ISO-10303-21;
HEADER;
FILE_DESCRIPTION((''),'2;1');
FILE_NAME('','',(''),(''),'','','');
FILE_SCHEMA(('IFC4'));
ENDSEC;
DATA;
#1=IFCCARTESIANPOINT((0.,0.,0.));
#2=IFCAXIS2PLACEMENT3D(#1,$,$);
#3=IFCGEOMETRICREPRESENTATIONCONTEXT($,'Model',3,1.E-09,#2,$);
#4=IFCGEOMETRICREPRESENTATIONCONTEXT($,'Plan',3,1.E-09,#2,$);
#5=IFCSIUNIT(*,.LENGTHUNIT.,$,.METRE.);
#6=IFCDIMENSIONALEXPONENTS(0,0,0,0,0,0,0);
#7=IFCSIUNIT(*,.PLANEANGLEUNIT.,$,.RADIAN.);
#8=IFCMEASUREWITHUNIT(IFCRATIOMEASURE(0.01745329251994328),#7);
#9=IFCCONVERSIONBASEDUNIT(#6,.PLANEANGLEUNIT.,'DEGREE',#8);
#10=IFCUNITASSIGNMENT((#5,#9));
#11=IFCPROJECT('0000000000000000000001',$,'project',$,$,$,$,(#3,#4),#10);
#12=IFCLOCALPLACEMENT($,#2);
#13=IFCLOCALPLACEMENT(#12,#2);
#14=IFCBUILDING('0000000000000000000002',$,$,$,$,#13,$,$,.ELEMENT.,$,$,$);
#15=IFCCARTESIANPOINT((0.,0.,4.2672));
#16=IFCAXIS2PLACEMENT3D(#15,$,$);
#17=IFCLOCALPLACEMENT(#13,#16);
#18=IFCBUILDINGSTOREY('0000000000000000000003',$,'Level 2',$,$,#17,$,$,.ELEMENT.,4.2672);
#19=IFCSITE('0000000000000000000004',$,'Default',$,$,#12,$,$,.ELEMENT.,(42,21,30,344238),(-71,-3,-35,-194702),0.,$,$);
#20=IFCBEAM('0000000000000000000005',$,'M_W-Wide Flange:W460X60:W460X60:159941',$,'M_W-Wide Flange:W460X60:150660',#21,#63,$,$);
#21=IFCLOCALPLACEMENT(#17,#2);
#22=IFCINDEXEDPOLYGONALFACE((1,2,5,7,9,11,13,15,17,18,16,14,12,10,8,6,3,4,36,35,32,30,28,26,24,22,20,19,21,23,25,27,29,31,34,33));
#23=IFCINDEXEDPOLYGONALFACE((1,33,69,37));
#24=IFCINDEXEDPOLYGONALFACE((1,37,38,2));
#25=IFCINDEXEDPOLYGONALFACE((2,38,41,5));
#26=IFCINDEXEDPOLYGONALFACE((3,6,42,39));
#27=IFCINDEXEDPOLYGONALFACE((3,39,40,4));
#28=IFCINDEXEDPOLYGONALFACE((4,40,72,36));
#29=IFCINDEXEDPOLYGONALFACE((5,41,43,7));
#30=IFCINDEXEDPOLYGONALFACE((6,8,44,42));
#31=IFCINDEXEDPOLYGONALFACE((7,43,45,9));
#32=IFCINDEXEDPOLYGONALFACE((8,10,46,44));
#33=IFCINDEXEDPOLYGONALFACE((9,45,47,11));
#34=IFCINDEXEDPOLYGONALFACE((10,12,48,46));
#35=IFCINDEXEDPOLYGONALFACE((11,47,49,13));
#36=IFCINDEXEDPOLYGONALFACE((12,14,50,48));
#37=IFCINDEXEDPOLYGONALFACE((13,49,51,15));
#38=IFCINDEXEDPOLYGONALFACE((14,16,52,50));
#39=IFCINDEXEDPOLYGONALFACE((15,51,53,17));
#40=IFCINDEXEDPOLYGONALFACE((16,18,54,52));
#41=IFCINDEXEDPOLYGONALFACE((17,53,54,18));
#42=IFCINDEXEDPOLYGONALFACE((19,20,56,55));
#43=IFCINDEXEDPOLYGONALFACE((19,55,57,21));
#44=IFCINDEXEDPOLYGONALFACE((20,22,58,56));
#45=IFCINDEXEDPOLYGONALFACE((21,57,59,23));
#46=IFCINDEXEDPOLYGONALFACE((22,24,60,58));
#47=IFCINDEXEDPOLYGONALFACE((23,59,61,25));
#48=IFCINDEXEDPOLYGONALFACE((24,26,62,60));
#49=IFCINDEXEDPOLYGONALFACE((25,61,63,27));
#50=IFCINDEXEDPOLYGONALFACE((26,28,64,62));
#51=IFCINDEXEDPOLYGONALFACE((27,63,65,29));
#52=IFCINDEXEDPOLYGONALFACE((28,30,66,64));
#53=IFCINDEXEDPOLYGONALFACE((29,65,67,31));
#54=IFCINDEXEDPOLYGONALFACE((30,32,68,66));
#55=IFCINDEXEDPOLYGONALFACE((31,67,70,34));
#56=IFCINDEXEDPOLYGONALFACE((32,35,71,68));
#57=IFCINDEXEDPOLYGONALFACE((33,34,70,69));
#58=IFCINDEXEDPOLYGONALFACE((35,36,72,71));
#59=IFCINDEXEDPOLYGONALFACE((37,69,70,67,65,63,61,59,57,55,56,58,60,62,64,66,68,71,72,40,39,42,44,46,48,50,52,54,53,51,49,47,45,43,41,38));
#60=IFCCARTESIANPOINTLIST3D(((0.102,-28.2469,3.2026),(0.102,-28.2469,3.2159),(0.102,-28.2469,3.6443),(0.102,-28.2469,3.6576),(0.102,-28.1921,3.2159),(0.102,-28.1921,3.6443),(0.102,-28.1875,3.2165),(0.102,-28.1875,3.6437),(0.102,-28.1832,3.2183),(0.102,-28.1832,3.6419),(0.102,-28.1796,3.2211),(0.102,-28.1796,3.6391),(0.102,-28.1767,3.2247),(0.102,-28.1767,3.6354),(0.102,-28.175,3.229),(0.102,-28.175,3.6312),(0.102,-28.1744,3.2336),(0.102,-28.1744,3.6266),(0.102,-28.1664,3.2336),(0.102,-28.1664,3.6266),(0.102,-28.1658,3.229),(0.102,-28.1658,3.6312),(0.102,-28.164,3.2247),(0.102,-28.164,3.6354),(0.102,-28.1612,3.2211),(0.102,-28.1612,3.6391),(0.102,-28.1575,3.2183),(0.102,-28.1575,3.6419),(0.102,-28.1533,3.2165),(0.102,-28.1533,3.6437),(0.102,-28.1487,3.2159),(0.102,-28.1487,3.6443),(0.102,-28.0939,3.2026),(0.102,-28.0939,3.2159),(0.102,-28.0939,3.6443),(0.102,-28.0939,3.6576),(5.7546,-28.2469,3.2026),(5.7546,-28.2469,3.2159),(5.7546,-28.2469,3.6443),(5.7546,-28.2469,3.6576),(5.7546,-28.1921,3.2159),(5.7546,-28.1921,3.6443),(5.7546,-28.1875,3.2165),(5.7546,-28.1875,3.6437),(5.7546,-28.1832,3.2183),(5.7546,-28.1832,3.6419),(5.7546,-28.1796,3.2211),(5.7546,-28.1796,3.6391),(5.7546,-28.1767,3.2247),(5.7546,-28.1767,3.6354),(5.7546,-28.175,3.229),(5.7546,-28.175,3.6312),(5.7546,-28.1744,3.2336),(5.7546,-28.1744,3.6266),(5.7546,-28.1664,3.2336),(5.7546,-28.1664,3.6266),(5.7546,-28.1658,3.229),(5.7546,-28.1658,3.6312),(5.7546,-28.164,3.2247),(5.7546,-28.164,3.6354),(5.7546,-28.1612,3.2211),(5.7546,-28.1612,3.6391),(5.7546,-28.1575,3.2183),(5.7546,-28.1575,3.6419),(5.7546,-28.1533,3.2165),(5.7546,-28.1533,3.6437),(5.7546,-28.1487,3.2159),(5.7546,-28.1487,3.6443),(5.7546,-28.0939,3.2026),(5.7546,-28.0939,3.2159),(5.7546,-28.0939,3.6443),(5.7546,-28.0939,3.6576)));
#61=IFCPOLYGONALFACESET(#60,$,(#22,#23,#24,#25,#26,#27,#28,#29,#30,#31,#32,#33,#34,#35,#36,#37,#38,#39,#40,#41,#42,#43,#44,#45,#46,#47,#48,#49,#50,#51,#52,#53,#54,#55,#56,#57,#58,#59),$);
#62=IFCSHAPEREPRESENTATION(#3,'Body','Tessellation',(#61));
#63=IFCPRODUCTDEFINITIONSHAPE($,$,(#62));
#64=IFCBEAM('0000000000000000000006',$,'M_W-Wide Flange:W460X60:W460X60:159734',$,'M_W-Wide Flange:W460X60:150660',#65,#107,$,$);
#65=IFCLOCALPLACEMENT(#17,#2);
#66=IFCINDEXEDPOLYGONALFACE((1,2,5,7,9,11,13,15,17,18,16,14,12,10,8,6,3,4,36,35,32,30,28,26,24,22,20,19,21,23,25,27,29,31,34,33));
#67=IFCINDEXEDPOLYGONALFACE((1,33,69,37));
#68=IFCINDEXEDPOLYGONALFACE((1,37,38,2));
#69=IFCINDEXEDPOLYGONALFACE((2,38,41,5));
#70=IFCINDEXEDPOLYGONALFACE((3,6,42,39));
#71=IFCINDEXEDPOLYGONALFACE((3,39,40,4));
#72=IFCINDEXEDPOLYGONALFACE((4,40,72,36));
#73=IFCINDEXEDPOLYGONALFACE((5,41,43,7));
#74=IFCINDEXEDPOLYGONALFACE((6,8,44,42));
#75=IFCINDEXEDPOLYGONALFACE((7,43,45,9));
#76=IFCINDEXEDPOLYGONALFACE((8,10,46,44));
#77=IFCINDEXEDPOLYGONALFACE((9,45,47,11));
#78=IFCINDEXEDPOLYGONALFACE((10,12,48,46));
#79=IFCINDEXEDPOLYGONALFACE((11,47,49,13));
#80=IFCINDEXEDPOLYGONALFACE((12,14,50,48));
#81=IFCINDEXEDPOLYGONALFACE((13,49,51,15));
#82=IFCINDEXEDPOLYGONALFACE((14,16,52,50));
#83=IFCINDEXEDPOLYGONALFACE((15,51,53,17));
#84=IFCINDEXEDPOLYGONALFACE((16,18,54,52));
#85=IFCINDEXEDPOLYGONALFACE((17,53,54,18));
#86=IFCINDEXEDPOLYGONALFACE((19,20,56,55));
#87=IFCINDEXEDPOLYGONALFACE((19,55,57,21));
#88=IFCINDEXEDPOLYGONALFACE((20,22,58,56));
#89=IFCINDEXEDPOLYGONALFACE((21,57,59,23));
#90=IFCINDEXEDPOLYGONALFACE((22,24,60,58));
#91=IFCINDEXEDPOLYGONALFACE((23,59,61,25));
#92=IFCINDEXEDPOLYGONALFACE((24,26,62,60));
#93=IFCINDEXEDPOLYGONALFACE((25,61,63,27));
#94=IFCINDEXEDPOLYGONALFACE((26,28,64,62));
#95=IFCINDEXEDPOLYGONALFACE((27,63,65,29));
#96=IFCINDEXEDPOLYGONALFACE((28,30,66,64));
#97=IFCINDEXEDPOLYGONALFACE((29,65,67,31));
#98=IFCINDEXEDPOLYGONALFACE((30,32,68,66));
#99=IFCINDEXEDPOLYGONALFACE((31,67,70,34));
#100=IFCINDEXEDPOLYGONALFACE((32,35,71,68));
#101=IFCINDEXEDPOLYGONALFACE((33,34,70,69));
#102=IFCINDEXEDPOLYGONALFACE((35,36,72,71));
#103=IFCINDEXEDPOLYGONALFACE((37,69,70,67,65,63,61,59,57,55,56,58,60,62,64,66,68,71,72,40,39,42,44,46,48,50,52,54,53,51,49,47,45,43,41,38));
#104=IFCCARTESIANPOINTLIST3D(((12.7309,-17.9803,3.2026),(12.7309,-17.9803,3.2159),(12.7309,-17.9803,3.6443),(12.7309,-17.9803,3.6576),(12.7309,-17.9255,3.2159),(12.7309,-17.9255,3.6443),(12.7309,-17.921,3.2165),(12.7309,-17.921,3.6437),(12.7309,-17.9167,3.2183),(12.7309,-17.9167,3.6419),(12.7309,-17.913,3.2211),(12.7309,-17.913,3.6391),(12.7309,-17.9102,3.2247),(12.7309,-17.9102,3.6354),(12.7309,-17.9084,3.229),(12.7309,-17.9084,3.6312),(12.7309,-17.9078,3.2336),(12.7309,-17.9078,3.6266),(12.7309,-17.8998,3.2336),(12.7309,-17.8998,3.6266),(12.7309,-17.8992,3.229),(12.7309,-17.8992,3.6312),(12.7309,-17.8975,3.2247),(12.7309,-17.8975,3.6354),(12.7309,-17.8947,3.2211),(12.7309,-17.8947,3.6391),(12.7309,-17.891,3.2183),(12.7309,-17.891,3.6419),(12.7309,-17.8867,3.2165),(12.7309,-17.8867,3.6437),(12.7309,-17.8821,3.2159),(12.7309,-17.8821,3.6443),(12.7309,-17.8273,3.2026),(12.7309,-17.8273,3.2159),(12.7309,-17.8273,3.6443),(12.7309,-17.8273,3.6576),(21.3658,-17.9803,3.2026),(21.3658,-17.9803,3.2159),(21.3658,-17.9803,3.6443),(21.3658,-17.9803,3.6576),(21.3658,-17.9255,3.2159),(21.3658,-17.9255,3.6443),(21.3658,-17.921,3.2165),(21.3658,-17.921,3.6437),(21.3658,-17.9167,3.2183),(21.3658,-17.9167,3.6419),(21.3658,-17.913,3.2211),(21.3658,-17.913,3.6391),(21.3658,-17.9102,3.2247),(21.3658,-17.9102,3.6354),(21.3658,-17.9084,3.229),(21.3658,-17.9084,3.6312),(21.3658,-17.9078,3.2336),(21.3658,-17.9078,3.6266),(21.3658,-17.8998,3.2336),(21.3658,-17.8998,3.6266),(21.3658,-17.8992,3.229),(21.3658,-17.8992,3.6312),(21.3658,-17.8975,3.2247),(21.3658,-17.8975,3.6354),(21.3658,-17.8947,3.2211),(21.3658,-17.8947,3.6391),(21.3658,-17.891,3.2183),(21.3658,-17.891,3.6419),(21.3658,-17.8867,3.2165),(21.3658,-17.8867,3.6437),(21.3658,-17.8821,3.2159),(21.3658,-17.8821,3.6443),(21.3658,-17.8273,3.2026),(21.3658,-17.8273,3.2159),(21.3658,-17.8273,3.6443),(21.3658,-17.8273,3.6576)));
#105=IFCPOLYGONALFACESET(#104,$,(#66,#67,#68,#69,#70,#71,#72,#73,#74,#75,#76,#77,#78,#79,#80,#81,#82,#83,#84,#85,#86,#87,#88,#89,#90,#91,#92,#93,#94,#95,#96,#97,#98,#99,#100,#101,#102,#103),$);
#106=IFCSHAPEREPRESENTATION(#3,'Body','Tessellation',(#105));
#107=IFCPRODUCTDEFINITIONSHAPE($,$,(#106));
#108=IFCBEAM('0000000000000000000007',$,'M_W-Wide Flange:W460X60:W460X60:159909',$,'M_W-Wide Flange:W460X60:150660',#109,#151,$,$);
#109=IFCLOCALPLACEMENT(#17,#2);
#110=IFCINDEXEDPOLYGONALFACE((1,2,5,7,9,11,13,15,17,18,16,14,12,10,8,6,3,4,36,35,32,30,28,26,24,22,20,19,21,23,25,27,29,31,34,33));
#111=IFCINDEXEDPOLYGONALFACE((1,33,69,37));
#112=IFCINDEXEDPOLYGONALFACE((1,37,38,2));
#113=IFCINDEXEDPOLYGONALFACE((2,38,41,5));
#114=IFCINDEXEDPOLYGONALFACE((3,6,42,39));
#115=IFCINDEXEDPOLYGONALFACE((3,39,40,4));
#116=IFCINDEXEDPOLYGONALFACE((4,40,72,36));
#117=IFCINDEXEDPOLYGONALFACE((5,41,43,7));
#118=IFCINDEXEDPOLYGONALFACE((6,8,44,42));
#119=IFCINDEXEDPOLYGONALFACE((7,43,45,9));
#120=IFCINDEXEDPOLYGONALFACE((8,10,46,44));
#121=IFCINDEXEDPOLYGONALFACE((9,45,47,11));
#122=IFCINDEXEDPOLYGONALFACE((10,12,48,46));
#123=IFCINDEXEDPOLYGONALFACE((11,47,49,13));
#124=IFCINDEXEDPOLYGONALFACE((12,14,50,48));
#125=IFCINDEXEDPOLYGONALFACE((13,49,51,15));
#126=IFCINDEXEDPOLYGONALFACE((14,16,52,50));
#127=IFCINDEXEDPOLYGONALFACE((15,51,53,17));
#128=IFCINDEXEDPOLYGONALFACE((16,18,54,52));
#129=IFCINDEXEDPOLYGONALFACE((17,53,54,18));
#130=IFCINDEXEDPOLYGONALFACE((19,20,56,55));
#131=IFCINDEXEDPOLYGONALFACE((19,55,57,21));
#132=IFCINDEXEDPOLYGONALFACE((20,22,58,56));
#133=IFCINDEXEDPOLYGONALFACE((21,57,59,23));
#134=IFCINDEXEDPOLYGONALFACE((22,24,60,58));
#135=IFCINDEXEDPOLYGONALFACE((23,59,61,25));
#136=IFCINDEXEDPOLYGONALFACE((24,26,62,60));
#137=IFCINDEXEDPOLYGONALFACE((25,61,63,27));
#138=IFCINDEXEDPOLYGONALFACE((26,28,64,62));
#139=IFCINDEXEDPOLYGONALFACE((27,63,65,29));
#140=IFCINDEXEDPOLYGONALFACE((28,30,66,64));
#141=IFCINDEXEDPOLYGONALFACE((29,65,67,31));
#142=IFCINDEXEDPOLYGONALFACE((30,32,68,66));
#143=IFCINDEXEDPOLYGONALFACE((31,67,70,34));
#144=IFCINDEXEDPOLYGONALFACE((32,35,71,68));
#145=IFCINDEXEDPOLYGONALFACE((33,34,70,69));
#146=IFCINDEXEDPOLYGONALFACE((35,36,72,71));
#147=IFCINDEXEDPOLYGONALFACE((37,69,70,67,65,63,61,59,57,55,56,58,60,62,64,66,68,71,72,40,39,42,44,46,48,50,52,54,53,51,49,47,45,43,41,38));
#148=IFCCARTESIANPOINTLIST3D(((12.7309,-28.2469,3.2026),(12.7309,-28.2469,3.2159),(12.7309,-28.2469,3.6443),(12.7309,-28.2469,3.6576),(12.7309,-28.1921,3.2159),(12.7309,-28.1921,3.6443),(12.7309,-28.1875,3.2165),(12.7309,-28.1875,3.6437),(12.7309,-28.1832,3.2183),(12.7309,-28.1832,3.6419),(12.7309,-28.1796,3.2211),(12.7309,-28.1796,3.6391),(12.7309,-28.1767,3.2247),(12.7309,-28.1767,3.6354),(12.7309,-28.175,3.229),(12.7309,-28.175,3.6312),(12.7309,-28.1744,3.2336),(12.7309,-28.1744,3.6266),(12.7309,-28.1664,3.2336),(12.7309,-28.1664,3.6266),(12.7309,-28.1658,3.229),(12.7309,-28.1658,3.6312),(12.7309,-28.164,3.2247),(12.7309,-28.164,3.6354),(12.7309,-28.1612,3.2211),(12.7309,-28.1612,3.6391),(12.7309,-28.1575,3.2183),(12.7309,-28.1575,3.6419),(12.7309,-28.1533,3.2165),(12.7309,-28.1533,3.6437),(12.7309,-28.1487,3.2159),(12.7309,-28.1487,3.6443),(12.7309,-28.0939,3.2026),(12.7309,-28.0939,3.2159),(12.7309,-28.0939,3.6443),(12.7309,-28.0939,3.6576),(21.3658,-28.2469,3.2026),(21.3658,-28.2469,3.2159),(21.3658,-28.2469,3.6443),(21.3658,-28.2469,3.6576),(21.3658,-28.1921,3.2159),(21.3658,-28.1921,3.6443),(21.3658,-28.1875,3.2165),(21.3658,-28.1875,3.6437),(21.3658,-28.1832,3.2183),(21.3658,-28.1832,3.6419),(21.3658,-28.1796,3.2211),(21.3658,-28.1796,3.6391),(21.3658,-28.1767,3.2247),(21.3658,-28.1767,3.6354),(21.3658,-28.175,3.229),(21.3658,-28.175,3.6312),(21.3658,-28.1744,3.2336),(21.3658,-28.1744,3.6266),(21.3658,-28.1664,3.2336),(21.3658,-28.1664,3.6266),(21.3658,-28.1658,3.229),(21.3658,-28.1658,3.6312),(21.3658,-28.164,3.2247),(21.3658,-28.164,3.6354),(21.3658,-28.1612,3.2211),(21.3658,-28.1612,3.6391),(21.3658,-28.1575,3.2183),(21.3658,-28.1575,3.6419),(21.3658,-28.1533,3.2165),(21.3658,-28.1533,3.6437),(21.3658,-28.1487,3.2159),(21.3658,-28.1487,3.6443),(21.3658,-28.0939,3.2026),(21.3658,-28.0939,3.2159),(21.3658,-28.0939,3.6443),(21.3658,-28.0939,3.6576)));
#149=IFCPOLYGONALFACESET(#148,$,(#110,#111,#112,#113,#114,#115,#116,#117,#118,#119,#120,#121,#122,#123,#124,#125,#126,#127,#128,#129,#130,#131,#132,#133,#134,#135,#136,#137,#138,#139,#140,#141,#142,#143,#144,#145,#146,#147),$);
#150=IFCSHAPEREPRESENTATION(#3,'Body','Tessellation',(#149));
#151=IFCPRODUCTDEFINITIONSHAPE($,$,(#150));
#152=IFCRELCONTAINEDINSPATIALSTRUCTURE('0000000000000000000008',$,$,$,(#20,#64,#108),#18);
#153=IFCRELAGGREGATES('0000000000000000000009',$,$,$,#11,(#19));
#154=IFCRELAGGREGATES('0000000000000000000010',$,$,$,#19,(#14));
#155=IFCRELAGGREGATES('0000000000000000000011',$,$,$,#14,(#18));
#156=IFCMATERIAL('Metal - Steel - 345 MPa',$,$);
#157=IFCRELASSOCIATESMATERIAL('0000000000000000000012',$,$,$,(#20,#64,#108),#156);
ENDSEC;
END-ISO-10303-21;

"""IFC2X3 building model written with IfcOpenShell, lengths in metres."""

from ifc_helpers import new_model, entity, si_unit, converted_unit, frame, frame_2d, origin, place, context, project, spatial, polyline, circle_curve, parameter, trimmed, segment, composite_curve, outline, extrude, material, element, save


model = new_model("IFC2X3")

# Units and contexts
model_context = context("Model", 3, precision=1e-09, world=origin())
plan_context = context("Plan", 3, precision=1e-09, world=origin())
ifc_project = project(units=[si_unit("LENGTHUNIT", "METRE"), converted_unit("PLANEANGLEUNIT", "DEGREE", entity("IfcRatioMeasure", 0.01745329251994328), si_unit("PLANEANGLEUNIT", "RADIAN"), dimensions=[0, 0, 0, 0, 0, 0, 0])], contexts=[model_context, plan_context])

# Site, building, storey
site_placement = place(None, origin())
site = spatial("IfcSite", under=ifc_project, at=site_placement, Name="Default", CompositionType="ELEMENT", RefLatitude=(42, 21, 30, 344238), RefLongitude=(-71, -3, -35, -194702), RefElevation=0.0)
building_placement = place(site_placement, origin())
building = spatial("IfcBuilding", under=site, at=building_placement, CompositionType="ELEMENT")
storey_placement = place(building_placement, frame((0.0, 0.0, 4.2672)))
storey = spatial("IfcBuildingStorey", under=building, at=storey_placement, Name="Level 2", CompositionType="ELEMENT", Elevation=4.2672)

# Shared definitions
ifc_material_1 = material(Name="Metal - Steel - 345 MPa")

# Beams
beam_1_placement = place(storey_placement, frame((5.8566, -28.1704, 3.6576), z_axis=(0.0, 0.0, 1.0), x_axis=(0.0, 1.0, 0.0)))
element("IfcBeam", 1, at=beam_1_placement, inside=storey, material=ifc_material_1, Name="M_W-Wide Flange:W460X60:W460X60:159941", ObjectType="M_W-Wide Flange:W460X60:150660", context=model_context, shape_type="SweptSolid", body=[
    extrude(outline(composite_curve([segment(polyline([(0.2142, -0.0765), (0.2275, -0.0765)]), True, "CONTINUOUS"), segment(polyline([(0.2275, -0.0765), (0.2275, 0.0765)]), True, "CONTINUOUS"), segment(polyline([(0.2275, 0.0765), (0.2142, 0.0765)]), True, "CONTINUOUS"), segment(polyline([(0.2142, 0.0765), (0.2142, 0.0217)]), True, "CONTINUOUS"), segment(trimmed(circle_curve(frame_2d((0.1965, 0.0217), x_axis=(0.0, 1.0)), 0.0177), [parameter(180.0)], [parameter(270.0)], True, "PARAMETER"), False, "CONTINUOUS"), segment(polyline([(0.1965, 0.004), (-0.1965, 0.004)]), True, "CONTINUOUS"), segment(trimmed(circle_curve(frame_2d((-0.1965, 0.0217), x_axis=(0.0, 1.0)), 0.0177), [parameter(90.0)], [parameter(180.0)], True, "PARAMETER"), False, "CONTINUOUS"), segment(polyline([(-0.2142, 0.0217), (-0.2142, 0.0765)]), True, "CONTINUOUS"), segment(polyline([(-0.2142, 0.0765), (-0.2275, 0.0765)]), True, "CONTINUOUS"), segment(polyline([(-0.2275, 0.0765), (-0.2275, -0.0765)]), True, "CONTINUOUS"), segment(polyline([(-0.2275, -0.0765), (-0.2142, -0.0765)]), True, "CONTINUOUS"), segment(polyline([(-0.2142, -0.0765), (-0.2142, -0.0217)]), True, "CONTINUOUS"), segment(trimmed(circle_curve(frame_2d((-0.1965, -0.0217), x_axis=(0.0, 1.0)), 0.0177), [parameter(360.0)], [parameter(90.0)], True, "PARAMETER"), False, "CONTINUOUS"), segment(polyline([(-0.1965, -0.004), (0.1965, -0.004)]), True, "CONTINUOUS"), segment(trimmed(circle_curve(frame_2d((0.1965, -0.0217), x_axis=(0.0, 1.0)), 0.0177), [parameter(270.0)], [parameter(0.0)], True, "PARAMETER"), False, "CONTINUOUS"), segment(polyline([(0.2142, -0.0217), (0.2142, -0.0765)]), True, "CONTINUOUS")], self_intersect=False)), frame((0.0, 5.7546, -0.2275), z_axis=(0.0, -1.0, 0.0), x_axis=(0.0, 0.0, -1.0)), (0.0, 0.0, 1.0), 5.6526),
])
beam_2_placement = place(storey_placement, frame((12.6289, -17.9038, 3.6576), z_axis=(0.0, 0.0, 1.0), x_axis=(0.0, -1.0, 0.0)))
element("IfcBeam", 2, at=beam_2_placement, inside=storey, material=ifc_material_1, Name="M_W-Wide Flange:W460X60:W460X60:159734", ObjectType="M_W-Wide Flange:W460X60:150660", context=model_context, shape_type="SweptSolid", body=[
    extrude(outline(composite_curve([segment(polyline([(-0.0765, -0.2142), (-0.0765, -0.2275)]), True, "CONTINUOUS"), segment(polyline([(-0.0765, -0.2275), (0.0765, -0.2275)]), True, "CONTINUOUS"), segment(polyline([(0.0765, -0.2275), (0.0765, -0.2142)]), True, "CONTINUOUS"), segment(polyline([(0.0765, -0.2142), (0.0217, -0.2142)]), True, "CONTINUOUS"), segment(trimmed(circle_curve(frame_2d((0.0217, -0.1965), x_axis=(0.0, -1.0)), 0.0177), [parameter(270.0)], [parameter(360.0)], True, "PARAMETER"), False, "CONTINUOUS"), segment(polyline([(0.004, -0.1965), (0.004, 0.1965)]), True, "CONTINUOUS"), segment(trimmed(circle_curve(frame_2d((0.0217, 0.1965), x_axis=(-1.0, 0.0)), 0.0177), [parameter(270.0)], [parameter(360.0)], True, "PARAMETER"), False, "CONTINUOUS"), segment(polyline([(0.0217, 0.2142), (0.0765, 0.2142)]), True, "CONTINUOUS"), segment(polyline([(0.0765, 0.2142), (0.0765, 0.2275)]), True, "CONTINUOUS"), segment(polyline([(0.0765, 0.2275), (-0.0765, 0.2275)]), True, "CONTINUOUS"), segment(polyline([(-0.0765, 0.2275), (-0.0765, 0.2142)]), True, "CONTINUOUS"), segment(polyline([(-0.0765, 0.2142), (-0.0217, 0.2142)]), True, "CONTINUOUS"), segment(trimmed(circle_curve(frame_2d((-0.0217, 0.1965), x_axis=(0.0, 1.0)), 0.0177), [parameter(270.0)], [parameter(360.0)], True, "PARAMETER"), False, "CONTINUOUS"), segment(polyline([(-0.004, 0.1965), (-0.004, -0.1965)]), True, "CONTINUOUS"), segment(trimmed(circle_curve(frame_2d((-0.0217, -0.1965), x_axis=(1.0, 0.0)), 0.0177), [parameter(270.0)], [parameter(0.0)], True, "PARAMETER"), False, "CONTINUOUS"), segment(polyline([(-0.0217, -0.2142), (-0.0765, -0.2142)]), True, "CONTINUOUS")], self_intersect=False)), frame((0.0, 0.102, -0.2275), z_axis=(0.0, -1.0, 0.0), x_axis=(1.0, 0.0, 0.0)), (0.0, 0.0, -1.0), 8.6349),
])
beam_3_placement = place(storey_placement, frame((21.4678, -28.1704, 3.6576), z_axis=(0.0, 0.0, 1.0), x_axis=(0.0, 1.0, 0.0)))
element("IfcBeam", 3, at=beam_3_placement, inside=storey, material=ifc_material_1, Name="M_W-Wide Flange:W460X60:W460X60:159909", ObjectType="M_W-Wide Flange:W460X60:150660", context=model_context, shape_type="SweptSolid", body=[
    extrude(outline(composite_curve([segment(polyline([(0.2142, -0.0765), (0.2275, -0.0765)]), True, "CONTINUOUS"), segment(polyline([(0.2275, -0.0765), (0.2275, 0.0765)]), True, "CONTINUOUS"), segment(polyline([(0.2275, 0.0765), (0.2142, 0.0765)]), True, "CONTINUOUS"), segment(polyline([(0.2142, 0.0765), (0.2142, 0.0217)]), True, "CONTINUOUS"), segment(trimmed(circle_curve(frame_2d((0.1965, 0.0217), x_axis=(1.0, 0.0)), 0.0177), [parameter(270.0)], [parameter(360.0)], True, "PARAMETER"), False, "CONTINUOUS"), segment(polyline([(0.1965, 0.004), (-0.1965, 0.004)]), True, "CONTINUOUS"), segment(trimmed(circle_curve(frame_2d((-0.1965, 0.0217), x_axis=(0.0, -1.0)), 0.0177), [parameter(270.0)], [parameter(360.0)], True, "PARAMETER"), False, "CONTINUOUS"), segment(polyline([(-0.2142, 0.0217), (-0.2142, 0.0765)]), True, "CONTINUOUS"), segment(polyline([(-0.2142, 0.0765), (-0.2275, 0.0765)]), True, "CONTINUOUS"), segment(polyline([(-0.2275, 0.0765), (-0.2275, -0.0765)]), True, "CONTINUOUS"), segment(polyline([(-0.2275, -0.0765), (-0.2142, -0.0765)]), True, "CONTINUOUS"), segment(polyline([(-0.2142, -0.0765), (-0.2142, -0.0217)]), True, "CONTINUOUS"), segment(trimmed(circle_curve(frame_2d((-0.1965, -0.0217), x_axis=(-1.0, 0.0)), 0.0177), [parameter(270.0)], [parameter(360.0)], True, "PARAMETER"), False, "CONTINUOUS"), segment(polyline([(-0.1965, -0.004), (0.1965, -0.004)]), True, "CONTINUOUS"), segment(trimmed(circle_curve(frame_2d((0.1965, -0.0217), x_axis=(0.0, 1.0)), 0.0177), [parameter(270.0)], [parameter(0.0)], True, "PARAMETER"), False, "CONTINUOUS"), segment(polyline([(0.2142, -0.0217), (0.2142, -0.0765)]), True, "CONTINUOUS")], self_intersect=False)), frame((0.0, 8.7369, -0.2275), z_axis=(0.0, -1.0, 0.0), x_axis=(0.0, 0.0, -1.0)), (0.0, 0.0, 1.0), 8.6349),
])

save(model, "model.ifc")
